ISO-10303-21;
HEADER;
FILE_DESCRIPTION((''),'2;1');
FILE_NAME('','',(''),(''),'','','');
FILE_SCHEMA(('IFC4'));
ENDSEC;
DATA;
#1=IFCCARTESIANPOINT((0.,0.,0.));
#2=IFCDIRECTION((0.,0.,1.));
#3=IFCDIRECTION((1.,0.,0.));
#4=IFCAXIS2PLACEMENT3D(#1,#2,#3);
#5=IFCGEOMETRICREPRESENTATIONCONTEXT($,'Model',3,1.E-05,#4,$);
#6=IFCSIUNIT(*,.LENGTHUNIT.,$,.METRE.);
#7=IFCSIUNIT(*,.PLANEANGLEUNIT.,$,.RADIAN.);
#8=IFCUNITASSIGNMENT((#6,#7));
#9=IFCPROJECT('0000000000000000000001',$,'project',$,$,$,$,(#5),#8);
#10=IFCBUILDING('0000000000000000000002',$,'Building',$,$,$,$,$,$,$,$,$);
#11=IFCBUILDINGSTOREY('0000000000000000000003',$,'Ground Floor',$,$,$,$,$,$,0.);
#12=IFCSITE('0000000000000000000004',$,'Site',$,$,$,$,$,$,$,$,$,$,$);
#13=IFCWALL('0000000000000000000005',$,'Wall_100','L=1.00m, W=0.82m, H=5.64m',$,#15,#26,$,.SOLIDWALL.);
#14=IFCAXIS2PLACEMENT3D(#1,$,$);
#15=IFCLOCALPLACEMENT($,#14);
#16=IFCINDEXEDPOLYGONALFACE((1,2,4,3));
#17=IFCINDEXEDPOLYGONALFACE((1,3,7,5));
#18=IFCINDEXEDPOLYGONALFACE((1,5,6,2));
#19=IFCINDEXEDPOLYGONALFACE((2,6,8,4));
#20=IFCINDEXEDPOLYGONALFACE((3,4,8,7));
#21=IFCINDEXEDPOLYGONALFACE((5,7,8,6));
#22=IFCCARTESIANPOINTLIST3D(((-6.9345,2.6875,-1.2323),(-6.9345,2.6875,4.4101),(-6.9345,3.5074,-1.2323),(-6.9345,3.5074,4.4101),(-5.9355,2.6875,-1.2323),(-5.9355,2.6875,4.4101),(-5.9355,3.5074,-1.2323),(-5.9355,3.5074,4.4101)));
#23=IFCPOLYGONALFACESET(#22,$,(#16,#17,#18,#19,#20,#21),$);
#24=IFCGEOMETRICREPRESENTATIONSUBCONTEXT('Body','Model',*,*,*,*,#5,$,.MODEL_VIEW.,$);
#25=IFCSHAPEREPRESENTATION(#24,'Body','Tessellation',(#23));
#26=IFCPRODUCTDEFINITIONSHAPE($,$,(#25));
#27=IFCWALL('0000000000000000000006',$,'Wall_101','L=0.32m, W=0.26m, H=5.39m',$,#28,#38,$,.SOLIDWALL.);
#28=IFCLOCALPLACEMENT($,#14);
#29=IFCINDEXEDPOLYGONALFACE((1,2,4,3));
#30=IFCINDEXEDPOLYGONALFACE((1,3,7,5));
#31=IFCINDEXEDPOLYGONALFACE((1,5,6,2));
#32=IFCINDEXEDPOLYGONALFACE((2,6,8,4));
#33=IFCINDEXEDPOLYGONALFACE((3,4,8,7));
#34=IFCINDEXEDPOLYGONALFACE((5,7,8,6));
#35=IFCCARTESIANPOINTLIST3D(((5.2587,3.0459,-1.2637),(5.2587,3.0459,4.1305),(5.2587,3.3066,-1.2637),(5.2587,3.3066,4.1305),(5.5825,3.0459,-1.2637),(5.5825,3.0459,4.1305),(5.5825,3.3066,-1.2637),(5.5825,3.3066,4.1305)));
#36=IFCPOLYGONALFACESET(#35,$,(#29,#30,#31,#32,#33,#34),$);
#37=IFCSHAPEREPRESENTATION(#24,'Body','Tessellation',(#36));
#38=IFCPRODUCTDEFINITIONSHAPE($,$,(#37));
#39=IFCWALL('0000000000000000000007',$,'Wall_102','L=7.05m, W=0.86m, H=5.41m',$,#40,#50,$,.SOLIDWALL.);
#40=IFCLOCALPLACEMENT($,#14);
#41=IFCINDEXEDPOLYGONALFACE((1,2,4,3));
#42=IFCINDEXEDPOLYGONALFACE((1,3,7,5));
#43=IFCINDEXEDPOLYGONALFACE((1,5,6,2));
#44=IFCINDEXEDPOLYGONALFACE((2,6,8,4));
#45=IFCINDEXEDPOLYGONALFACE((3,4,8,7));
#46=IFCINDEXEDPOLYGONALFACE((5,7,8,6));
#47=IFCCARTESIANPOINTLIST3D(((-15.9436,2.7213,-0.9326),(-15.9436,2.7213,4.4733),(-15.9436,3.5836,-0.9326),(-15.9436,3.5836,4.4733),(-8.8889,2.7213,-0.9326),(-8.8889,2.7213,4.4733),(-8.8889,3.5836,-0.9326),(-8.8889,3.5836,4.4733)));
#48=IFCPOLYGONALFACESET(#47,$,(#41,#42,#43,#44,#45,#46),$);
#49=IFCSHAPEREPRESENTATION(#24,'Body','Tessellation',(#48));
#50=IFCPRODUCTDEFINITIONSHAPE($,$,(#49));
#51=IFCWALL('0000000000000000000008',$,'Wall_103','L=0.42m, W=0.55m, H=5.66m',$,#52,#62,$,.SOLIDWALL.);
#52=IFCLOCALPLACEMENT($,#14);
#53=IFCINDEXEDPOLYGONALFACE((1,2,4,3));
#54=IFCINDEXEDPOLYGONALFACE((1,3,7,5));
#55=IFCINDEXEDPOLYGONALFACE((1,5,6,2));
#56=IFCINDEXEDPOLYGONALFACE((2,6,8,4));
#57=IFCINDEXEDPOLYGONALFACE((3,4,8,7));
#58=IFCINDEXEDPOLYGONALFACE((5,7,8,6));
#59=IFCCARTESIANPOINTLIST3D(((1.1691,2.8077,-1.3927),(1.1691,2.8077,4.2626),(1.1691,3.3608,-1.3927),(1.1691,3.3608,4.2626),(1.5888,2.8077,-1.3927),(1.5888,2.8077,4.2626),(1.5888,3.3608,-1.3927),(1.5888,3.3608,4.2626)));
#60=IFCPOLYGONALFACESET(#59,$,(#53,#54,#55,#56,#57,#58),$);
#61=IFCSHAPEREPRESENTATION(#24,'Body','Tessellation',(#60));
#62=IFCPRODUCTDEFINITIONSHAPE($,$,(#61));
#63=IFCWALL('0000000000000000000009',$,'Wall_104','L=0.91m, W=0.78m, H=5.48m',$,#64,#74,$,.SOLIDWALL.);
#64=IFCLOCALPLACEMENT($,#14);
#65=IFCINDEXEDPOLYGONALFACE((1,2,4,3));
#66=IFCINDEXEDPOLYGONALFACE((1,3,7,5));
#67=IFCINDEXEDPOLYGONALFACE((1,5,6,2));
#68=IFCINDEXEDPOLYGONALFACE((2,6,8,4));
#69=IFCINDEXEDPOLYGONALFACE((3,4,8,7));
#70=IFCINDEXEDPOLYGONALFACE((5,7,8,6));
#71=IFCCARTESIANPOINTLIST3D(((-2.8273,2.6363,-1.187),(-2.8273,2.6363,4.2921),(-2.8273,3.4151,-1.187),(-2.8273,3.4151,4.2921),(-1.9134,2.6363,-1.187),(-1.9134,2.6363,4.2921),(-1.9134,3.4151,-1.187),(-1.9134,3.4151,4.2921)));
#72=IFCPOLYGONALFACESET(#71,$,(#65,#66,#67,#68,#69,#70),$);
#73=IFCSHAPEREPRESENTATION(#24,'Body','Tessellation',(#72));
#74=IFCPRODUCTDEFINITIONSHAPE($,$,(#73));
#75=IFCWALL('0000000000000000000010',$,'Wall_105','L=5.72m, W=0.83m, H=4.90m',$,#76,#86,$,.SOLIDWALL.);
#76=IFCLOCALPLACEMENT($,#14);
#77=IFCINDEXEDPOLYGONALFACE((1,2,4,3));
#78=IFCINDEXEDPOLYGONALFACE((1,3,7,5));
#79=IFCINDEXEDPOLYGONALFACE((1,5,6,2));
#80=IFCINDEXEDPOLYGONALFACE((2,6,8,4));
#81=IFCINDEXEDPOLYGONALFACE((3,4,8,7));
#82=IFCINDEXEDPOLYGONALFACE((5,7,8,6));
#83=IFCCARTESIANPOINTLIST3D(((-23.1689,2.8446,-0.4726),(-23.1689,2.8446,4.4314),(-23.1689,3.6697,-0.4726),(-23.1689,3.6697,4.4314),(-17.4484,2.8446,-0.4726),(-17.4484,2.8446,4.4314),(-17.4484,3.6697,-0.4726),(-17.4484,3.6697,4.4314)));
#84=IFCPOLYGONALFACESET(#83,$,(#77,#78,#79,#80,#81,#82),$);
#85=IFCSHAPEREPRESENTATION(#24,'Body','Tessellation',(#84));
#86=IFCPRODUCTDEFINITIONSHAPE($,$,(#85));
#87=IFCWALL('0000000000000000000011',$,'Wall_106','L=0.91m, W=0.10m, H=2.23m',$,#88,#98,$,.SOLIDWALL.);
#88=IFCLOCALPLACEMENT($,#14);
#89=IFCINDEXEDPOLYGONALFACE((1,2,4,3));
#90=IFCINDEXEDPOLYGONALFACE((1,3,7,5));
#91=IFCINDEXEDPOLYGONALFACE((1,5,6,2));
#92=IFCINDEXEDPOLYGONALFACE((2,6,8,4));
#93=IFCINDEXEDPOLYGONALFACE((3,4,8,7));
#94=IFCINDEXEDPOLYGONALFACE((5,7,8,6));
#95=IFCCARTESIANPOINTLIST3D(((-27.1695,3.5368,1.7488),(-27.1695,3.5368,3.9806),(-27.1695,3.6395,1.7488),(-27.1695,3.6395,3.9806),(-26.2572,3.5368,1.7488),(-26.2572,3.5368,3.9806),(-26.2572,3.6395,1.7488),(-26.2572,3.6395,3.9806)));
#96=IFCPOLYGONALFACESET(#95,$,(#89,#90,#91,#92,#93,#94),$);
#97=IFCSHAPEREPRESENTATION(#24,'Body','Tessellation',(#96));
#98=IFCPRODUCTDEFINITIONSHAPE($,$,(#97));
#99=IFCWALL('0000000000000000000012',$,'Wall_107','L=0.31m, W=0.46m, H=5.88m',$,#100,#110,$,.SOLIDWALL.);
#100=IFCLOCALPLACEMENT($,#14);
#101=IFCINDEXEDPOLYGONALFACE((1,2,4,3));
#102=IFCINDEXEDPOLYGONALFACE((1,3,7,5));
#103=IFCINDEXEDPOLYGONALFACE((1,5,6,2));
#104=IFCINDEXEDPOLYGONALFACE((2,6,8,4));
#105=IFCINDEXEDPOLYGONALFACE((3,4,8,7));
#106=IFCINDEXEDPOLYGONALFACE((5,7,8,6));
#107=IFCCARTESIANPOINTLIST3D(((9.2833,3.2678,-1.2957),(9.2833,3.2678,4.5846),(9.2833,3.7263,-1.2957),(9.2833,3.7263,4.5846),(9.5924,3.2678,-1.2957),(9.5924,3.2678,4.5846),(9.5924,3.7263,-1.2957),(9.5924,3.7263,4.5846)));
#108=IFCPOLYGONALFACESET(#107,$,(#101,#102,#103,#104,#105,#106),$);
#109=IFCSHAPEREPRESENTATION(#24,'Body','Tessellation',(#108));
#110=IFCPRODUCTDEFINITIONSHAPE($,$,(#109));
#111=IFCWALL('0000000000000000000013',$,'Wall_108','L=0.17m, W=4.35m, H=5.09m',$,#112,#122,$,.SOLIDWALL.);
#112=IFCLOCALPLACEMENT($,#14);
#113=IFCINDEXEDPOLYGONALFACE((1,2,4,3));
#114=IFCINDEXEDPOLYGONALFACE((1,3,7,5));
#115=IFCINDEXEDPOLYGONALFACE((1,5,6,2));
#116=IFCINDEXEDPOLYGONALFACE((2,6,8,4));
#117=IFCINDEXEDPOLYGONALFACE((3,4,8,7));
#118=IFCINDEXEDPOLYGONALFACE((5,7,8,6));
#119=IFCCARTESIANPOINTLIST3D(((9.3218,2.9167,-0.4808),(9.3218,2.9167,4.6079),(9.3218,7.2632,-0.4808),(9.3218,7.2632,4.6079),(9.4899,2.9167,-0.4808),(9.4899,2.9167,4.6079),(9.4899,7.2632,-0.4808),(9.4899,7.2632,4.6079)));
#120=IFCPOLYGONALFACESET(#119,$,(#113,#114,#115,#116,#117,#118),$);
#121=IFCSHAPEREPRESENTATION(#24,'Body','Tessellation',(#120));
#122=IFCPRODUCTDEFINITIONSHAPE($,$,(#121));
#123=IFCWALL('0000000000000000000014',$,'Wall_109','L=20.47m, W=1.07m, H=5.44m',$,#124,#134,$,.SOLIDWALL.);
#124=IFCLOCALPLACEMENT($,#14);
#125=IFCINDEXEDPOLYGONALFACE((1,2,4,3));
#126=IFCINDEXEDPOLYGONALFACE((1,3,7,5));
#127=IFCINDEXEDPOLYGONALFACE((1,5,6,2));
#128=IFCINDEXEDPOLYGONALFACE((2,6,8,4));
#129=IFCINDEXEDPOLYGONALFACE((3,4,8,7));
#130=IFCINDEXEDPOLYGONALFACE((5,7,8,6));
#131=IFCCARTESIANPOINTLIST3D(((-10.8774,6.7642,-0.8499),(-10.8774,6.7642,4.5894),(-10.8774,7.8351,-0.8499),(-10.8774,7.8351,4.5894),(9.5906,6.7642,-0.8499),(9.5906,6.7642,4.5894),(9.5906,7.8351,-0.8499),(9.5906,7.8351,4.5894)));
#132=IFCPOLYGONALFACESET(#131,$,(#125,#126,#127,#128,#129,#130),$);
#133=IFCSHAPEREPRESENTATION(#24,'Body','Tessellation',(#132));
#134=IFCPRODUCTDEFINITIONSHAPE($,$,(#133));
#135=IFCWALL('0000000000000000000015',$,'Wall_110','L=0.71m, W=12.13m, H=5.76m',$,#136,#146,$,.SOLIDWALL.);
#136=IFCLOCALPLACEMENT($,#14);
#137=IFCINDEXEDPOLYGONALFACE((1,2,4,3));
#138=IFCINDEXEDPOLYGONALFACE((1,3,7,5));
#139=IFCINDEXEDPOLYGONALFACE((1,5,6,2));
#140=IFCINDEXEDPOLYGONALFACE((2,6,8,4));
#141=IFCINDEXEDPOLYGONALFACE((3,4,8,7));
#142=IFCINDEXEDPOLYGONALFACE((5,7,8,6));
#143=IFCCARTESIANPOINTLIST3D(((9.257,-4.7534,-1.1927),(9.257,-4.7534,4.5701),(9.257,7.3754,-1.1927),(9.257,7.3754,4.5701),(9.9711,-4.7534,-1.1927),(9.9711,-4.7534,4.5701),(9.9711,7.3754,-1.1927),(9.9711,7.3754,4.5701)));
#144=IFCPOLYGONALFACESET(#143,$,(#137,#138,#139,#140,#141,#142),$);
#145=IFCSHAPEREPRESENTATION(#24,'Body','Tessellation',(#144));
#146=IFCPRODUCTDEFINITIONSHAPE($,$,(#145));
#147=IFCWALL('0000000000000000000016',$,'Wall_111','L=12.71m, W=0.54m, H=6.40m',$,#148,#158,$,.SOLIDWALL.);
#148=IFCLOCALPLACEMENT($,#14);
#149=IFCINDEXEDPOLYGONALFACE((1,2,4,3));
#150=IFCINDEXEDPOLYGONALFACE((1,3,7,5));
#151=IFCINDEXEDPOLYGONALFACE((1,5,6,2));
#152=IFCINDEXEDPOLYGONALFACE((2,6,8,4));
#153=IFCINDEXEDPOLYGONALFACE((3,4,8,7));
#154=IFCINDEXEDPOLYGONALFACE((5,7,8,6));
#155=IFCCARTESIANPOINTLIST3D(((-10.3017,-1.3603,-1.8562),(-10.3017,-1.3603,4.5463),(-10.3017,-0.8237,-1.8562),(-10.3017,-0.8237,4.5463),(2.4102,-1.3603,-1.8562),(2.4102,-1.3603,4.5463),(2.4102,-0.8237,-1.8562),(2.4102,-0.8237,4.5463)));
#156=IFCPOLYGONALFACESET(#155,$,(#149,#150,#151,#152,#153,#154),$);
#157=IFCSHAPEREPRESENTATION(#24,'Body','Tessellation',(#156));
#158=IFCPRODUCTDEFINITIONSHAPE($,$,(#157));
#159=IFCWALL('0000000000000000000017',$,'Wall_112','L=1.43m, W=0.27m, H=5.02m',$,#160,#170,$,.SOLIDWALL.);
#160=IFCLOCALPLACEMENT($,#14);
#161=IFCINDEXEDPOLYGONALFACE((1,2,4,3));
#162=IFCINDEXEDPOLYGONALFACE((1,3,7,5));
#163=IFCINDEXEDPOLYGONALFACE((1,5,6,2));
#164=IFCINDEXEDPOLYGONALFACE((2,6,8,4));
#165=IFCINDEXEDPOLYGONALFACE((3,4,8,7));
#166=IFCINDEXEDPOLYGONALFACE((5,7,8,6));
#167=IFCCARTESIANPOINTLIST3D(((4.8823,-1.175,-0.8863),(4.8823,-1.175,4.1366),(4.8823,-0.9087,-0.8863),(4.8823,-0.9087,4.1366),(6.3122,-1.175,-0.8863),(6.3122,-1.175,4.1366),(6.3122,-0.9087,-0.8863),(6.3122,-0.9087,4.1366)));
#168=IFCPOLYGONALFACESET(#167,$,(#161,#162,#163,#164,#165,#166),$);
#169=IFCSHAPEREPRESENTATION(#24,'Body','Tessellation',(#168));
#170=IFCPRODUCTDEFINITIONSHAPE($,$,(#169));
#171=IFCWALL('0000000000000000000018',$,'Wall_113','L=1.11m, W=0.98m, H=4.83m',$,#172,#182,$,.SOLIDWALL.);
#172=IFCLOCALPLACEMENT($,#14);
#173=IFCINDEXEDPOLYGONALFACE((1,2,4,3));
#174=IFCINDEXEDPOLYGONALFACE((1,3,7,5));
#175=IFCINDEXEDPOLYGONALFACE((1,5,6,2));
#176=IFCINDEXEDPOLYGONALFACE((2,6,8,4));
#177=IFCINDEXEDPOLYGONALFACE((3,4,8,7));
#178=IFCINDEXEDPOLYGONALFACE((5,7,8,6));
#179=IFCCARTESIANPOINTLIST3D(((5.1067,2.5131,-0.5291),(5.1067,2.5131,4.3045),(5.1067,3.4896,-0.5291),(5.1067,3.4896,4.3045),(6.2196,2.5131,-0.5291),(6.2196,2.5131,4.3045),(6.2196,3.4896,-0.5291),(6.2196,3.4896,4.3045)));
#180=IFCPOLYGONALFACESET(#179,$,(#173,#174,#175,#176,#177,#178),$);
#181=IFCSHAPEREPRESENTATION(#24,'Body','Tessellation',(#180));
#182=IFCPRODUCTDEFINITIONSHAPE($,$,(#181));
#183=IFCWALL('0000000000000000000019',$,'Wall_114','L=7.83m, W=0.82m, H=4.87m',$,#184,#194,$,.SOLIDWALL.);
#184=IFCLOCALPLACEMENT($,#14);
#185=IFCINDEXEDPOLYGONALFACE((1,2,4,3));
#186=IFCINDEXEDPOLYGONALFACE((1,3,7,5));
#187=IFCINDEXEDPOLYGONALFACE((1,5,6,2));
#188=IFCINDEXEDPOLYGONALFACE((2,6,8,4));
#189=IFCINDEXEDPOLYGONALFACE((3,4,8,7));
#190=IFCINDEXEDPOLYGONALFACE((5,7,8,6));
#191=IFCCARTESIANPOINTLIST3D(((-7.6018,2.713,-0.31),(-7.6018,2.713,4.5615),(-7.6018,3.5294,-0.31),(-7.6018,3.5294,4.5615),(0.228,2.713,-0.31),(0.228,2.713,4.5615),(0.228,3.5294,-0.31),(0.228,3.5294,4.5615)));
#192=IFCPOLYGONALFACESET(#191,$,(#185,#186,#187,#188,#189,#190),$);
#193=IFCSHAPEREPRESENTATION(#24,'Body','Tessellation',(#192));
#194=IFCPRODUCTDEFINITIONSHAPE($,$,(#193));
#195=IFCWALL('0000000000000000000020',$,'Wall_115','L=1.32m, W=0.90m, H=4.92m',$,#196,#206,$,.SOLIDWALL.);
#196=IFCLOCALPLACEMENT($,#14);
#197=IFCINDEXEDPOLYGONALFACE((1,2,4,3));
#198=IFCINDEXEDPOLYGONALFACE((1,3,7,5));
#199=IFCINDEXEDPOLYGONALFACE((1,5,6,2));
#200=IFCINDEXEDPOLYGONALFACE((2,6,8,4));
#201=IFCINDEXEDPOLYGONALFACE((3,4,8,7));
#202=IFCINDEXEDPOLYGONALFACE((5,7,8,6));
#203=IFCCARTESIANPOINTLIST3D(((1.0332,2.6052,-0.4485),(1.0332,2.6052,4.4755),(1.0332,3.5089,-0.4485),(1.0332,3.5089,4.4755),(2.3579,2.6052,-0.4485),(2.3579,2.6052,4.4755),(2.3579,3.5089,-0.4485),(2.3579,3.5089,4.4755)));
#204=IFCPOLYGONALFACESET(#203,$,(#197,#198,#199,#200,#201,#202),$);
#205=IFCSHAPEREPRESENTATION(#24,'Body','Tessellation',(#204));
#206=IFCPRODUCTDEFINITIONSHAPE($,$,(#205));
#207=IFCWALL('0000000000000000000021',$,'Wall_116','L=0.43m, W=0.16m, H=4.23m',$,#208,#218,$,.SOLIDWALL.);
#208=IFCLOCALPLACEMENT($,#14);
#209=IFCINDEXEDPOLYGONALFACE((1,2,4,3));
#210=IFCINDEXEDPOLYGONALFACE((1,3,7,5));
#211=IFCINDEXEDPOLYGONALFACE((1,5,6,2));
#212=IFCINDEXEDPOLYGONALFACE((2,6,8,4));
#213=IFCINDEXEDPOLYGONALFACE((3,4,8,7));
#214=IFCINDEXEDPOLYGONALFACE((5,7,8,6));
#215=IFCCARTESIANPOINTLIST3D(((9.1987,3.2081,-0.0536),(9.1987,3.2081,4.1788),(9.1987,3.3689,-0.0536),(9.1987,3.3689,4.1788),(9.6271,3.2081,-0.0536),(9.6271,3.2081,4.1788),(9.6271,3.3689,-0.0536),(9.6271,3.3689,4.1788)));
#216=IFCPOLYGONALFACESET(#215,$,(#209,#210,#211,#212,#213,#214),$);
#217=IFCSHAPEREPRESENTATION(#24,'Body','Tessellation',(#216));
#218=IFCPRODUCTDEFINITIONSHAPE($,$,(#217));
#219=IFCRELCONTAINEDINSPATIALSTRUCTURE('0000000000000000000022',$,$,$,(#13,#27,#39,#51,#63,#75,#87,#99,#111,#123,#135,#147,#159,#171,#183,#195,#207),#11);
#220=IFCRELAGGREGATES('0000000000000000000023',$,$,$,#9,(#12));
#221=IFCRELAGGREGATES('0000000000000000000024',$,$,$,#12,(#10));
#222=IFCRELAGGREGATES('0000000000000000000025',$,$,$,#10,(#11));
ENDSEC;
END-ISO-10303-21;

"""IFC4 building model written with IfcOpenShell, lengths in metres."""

from ifc_helpers import new_model, si_unit, frame, origin_with_axes, origin_2d, context, subcontext, project, spatial, rectangle, extrude, element, save


model = new_model("IFC4")

# Units and contexts
model_context = context("Model", 3, precision=1e-05, world=origin_with_axes())
body_context = subcontext(model_context, "Body", "Model", "MODEL_VIEW")
ifc_project = project(units=[si_unit("LENGTHUNIT", "METRE"), si_unit("PLANEANGLEUNIT", "RADIAN")], contexts=[model_context])

# Site, building, storey
site = spatial("IfcSite", under=ifc_project, Name="Site")
building = spatial("IfcBuilding", under=site, Name="Building")
storey = spatial("IfcBuildingStorey", under=building, Name="Ground Floor", Elevation=0.0)

# Walls
element("IfcWall", 1, inside=storey, Name="Wall_100", Description="L=1.00m, W=0.82m, H=5.64m", PredefinedType="SOLIDWALL", context=body_context, shape_type="SweptSolid", body=[
    extrude(rectangle(XDim=0.999, YDim=0.8198, at=origin_2d()), frame((-6.435, 3.0974, -1.2323), z_axis=(0.0, 0.0, 1.0), x_axis=(1.0, 0.0, 0.0)), (0.0, 0.0, 1.0), 5.6424),
])
element("IfcWall", 2, inside=storey, Name="Wall_101", Description="L=0.32m, W=0.26m, H=5.39m", PredefinedType="SOLIDWALL", context=body_context, shape_type="SweptSolid", body=[
    extrude(rectangle(XDim=0.3237, YDim=0.2606, at=origin_2d()), frame((5.4206, 3.1763, -1.2637), z_axis=(0.0, 0.0, 1.0), x_axis=(1.0, 0.0, 0.0)), (0.0, 0.0, 1.0), 5.3941),
])
element("IfcWall", 3, inside=storey, Name="Wall_102", Description="L=7.05m, W=0.86m, H=5.41m", PredefinedType="SOLIDWALL", context=body_context, shape_type="SweptSolid", body=[
    extrude(rectangle(XDim=7.0547, YDim=0.8623, at=origin_2d()), frame((-12.4163, 3.1524, -0.9326), z_axis=(0.0, 0.0, 1.0), x_axis=(1.0, 0.0, 0.0)), (0.0, 0.0, 1.0), 5.4059),
])
element("IfcWall", 4, inside=storey, Name="Wall_103", Description="L=0.42m, W=0.55m, H=5.66m", PredefinedType="SOLIDWALL", context=body_context, shape_type="SweptSolid", body=[
    extrude(rectangle(XDim=0.4197, YDim=0.5531, at=origin_2d()), frame((1.379, 3.0842, -1.3927), z_axis=(0.0, 0.0, 1.0), x_axis=(1.0, 0.0, 0.0)), (0.0, 0.0, 1.0), 5.6553),
])
element("IfcWall", 5, inside=storey, Name="Wall_104", Description="L=0.91m, W=0.78m, H=5.48m", PredefinedType="SOLIDWALL", context=body_context, shape_type="SweptSolid", body=[
    extrude(rectangle(XDim=0.9138, YDim=0.7788, at=origin_2d()), frame((-2.3703, 3.0257, -1.187), z_axis=(0.0, 0.0, 1.0), x_axis=(1.0, 0.0, 0.0)), (0.0, 0.0, 1.0), 5.4791),
])
element("IfcWall", 6, inside=storey, Name="Wall_105", Description="L=5.72m, W=0.83m, H=4.90m", PredefinedType="SOLIDWALL", context=body_context, shape_type="SweptSolid", body=[
    extrude(rectangle(XDim=5.7205, YDim=0.8251, at=origin_2d()), frame((-20.3086, 3.2571, -0.4726), z_axis=(0.0, 0.0, 1.0), x_axis=(1.0, 0.0, 0.0)), (0.0, 0.0, 1.0), 4.9039),
])
element("IfcWall", 7, inside=storey, Name="Wall_106", Description="L=0.91m, W=0.10m, H=2.23m", PredefinedType="SOLIDWALL", context=body_context, shape_type="SweptSolid", body=[
    extrude(rectangle(XDim=0.9124, YDim=0.1028, at=origin_2d()), frame((-26.7134, 3.5881, 1.7488), z_axis=(0.0, 0.0, 1.0), x_axis=(1.0, 0.0, 0.0)), (0.0, 0.0, 1.0), 2.2317),
])
element("IfcWall", 8, inside=storey, Name="Wall_107", Description="L=0.31m, W=0.46m, H=5.88m", PredefinedType="SOLIDWALL", context=body_context, shape_type="SweptSolid", body=[
    extrude(rectangle(XDim=0.3092, YDim=0.4585, at=origin_2d()), frame((9.4379, 3.497, -1.2957), z_axis=(0.0, 0.0, 1.0), x_axis=(1.0, 0.0, 0.0)), (0.0, 0.0, 1.0), 5.8803),
])
element("IfcWall", 9, inside=storey, Name="Wall_108", Description="L=0.17m, W=4.35m, H=5.09m", PredefinedType="SOLIDWALL", context=body_context, shape_type="SweptSolid", body=[
    extrude(rectangle(XDim=0.1681, YDim=4.3465, at=origin_2d()), frame((9.4059, 5.09, -0.4808), z_axis=(0.0, 0.0, 1.0), x_axis=(1.0, 0.0, 0.0)), (0.0, 0.0, 1.0), 5.0886),
])
element("IfcWall", 10, inside=storey, Name="Wall_109", Description="L=20.47m, W=1.07m, H=5.44m", PredefinedType="SOLIDWALL", context=body_context, shape_type="SweptSolid", body=[
    extrude(rectangle(XDim=20.468, YDim=1.0709, at=origin_2d()), frame((-0.6434, 7.2996, -0.8499), z_axis=(0.0, 0.0, 1.0), x_axis=(1.0, 0.0, 0.0)), (0.0, 0.0, 1.0), 5.4393),
])
element("IfcWall", 11, inside=storey, Name="Wall_110", Description="L=0.71m, W=12.13m, H=5.76m", PredefinedType="SOLIDWALL", context=body_context, shape_type="SweptSolid", body=[
    extrude(rectangle(XDim=0.7141, YDim=12.1288, at=origin_2d()), frame((9.614, 1.311, -1.1927), z_axis=(0.0, 0.0, 1.0), x_axis=(1.0, 0.0, 0.0)), (0.0, 0.0, 1.0), 5.7628),
])
element("IfcWall", 12, inside=storey, Name="Wall_111", Description="L=12.71m, W=0.54m, H=6.40m", PredefinedType="SOLIDWALL", context=body_context, shape_type="SweptSolid", body=[
    extrude(rectangle(XDim=12.7119, YDim=0.5366, at=origin_2d()), frame((-3.9457, -1.092, -1.8562), z_axis=(0.0, 0.0, 1.0), x_axis=(1.0, 0.0, 0.0)), (0.0, 0.0, 1.0), 6.4025),
])
element("IfcWall", 13, inside=storey, Name="Wall_112", Description="L=1.43m, W=0.27m, H=5.02m", PredefinedType="SOLIDWALL", context=body_context, shape_type="SweptSolid", body=[
    extrude(rectangle(XDim=1.43, YDim=0.2663, at=origin_2d()), frame((5.5972, -1.0419, -0.8863), z_axis=(0.0, 0.0, 1.0), x_axis=(1.0, 0.0, 0.0)), (0.0, 0.0, 1.0), 5.0229),
])
element("IfcWall", 14, inside=storey, Name="Wall_113", Description="L=1.11m, W=0.98m, H=4.83m", PredefinedType="SOLIDWALL", context=body_context, shape_type="SweptSolid", body=[
    extrude(rectangle(XDim=1.1129, YDim=0.9766, at=origin_2d()), frame((5.6631, 3.0014, -0.5291), z_axis=(0.0, 0.0, 1.0), x_axis=(1.0, 0.0, 0.0)), (0.0, 0.0, 1.0), 4.8336),
])
element("IfcWall", 15, inside=storey, Name="Wall_114", Description="L=7.83m, W=0.82m, H=4.87m", PredefinedType="SOLIDWALL", context=body_context, shape_type="SweptSolid", body=[
    extrude(rectangle(XDim=7.8298, YDim=0.8164, at=origin_2d()), frame((-3.6869, 3.1212, -0.31), z_axis=(0.0, 0.0, 1.0), x_axis=(1.0, 0.0, 0.0)), (0.0, 0.0, 1.0), 4.8715),
])
element("IfcWall", 16, inside=storey, Name="Wall_115", Description="L=1.32m, W=0.90m, H=4.92m", PredefinedType="SOLIDWALL", context=body_context, shape_type="SweptSolid", body=[
    extrude(rectangle(XDim=1.3247, YDim=0.9036, at=origin_2d()), frame((1.6956, 3.057, -0.4485), z_axis=(0.0, 0.0, 1.0), x_axis=(1.0, 0.0, 0.0)), (0.0, 0.0, 1.0), 4.924),
])
element("IfcWall", 17, inside=storey, Name="Wall_116", Description="L=0.43m, W=0.16m, H=4.23m", PredefinedType="SOLIDWALL", context=body_context, shape_type="SweptSolid", body=[
    extrude(rectangle(XDim=0.4285, YDim=0.1607, at=origin_2d()), frame((9.4129, 3.2885, -0.0536), z_axis=(0.0, 0.0, 1.0), x_axis=(1.0, 0.0, 0.0)), (0.0, 0.0, 1.0), 4.2324),
])

save(model, "model.ifc")
